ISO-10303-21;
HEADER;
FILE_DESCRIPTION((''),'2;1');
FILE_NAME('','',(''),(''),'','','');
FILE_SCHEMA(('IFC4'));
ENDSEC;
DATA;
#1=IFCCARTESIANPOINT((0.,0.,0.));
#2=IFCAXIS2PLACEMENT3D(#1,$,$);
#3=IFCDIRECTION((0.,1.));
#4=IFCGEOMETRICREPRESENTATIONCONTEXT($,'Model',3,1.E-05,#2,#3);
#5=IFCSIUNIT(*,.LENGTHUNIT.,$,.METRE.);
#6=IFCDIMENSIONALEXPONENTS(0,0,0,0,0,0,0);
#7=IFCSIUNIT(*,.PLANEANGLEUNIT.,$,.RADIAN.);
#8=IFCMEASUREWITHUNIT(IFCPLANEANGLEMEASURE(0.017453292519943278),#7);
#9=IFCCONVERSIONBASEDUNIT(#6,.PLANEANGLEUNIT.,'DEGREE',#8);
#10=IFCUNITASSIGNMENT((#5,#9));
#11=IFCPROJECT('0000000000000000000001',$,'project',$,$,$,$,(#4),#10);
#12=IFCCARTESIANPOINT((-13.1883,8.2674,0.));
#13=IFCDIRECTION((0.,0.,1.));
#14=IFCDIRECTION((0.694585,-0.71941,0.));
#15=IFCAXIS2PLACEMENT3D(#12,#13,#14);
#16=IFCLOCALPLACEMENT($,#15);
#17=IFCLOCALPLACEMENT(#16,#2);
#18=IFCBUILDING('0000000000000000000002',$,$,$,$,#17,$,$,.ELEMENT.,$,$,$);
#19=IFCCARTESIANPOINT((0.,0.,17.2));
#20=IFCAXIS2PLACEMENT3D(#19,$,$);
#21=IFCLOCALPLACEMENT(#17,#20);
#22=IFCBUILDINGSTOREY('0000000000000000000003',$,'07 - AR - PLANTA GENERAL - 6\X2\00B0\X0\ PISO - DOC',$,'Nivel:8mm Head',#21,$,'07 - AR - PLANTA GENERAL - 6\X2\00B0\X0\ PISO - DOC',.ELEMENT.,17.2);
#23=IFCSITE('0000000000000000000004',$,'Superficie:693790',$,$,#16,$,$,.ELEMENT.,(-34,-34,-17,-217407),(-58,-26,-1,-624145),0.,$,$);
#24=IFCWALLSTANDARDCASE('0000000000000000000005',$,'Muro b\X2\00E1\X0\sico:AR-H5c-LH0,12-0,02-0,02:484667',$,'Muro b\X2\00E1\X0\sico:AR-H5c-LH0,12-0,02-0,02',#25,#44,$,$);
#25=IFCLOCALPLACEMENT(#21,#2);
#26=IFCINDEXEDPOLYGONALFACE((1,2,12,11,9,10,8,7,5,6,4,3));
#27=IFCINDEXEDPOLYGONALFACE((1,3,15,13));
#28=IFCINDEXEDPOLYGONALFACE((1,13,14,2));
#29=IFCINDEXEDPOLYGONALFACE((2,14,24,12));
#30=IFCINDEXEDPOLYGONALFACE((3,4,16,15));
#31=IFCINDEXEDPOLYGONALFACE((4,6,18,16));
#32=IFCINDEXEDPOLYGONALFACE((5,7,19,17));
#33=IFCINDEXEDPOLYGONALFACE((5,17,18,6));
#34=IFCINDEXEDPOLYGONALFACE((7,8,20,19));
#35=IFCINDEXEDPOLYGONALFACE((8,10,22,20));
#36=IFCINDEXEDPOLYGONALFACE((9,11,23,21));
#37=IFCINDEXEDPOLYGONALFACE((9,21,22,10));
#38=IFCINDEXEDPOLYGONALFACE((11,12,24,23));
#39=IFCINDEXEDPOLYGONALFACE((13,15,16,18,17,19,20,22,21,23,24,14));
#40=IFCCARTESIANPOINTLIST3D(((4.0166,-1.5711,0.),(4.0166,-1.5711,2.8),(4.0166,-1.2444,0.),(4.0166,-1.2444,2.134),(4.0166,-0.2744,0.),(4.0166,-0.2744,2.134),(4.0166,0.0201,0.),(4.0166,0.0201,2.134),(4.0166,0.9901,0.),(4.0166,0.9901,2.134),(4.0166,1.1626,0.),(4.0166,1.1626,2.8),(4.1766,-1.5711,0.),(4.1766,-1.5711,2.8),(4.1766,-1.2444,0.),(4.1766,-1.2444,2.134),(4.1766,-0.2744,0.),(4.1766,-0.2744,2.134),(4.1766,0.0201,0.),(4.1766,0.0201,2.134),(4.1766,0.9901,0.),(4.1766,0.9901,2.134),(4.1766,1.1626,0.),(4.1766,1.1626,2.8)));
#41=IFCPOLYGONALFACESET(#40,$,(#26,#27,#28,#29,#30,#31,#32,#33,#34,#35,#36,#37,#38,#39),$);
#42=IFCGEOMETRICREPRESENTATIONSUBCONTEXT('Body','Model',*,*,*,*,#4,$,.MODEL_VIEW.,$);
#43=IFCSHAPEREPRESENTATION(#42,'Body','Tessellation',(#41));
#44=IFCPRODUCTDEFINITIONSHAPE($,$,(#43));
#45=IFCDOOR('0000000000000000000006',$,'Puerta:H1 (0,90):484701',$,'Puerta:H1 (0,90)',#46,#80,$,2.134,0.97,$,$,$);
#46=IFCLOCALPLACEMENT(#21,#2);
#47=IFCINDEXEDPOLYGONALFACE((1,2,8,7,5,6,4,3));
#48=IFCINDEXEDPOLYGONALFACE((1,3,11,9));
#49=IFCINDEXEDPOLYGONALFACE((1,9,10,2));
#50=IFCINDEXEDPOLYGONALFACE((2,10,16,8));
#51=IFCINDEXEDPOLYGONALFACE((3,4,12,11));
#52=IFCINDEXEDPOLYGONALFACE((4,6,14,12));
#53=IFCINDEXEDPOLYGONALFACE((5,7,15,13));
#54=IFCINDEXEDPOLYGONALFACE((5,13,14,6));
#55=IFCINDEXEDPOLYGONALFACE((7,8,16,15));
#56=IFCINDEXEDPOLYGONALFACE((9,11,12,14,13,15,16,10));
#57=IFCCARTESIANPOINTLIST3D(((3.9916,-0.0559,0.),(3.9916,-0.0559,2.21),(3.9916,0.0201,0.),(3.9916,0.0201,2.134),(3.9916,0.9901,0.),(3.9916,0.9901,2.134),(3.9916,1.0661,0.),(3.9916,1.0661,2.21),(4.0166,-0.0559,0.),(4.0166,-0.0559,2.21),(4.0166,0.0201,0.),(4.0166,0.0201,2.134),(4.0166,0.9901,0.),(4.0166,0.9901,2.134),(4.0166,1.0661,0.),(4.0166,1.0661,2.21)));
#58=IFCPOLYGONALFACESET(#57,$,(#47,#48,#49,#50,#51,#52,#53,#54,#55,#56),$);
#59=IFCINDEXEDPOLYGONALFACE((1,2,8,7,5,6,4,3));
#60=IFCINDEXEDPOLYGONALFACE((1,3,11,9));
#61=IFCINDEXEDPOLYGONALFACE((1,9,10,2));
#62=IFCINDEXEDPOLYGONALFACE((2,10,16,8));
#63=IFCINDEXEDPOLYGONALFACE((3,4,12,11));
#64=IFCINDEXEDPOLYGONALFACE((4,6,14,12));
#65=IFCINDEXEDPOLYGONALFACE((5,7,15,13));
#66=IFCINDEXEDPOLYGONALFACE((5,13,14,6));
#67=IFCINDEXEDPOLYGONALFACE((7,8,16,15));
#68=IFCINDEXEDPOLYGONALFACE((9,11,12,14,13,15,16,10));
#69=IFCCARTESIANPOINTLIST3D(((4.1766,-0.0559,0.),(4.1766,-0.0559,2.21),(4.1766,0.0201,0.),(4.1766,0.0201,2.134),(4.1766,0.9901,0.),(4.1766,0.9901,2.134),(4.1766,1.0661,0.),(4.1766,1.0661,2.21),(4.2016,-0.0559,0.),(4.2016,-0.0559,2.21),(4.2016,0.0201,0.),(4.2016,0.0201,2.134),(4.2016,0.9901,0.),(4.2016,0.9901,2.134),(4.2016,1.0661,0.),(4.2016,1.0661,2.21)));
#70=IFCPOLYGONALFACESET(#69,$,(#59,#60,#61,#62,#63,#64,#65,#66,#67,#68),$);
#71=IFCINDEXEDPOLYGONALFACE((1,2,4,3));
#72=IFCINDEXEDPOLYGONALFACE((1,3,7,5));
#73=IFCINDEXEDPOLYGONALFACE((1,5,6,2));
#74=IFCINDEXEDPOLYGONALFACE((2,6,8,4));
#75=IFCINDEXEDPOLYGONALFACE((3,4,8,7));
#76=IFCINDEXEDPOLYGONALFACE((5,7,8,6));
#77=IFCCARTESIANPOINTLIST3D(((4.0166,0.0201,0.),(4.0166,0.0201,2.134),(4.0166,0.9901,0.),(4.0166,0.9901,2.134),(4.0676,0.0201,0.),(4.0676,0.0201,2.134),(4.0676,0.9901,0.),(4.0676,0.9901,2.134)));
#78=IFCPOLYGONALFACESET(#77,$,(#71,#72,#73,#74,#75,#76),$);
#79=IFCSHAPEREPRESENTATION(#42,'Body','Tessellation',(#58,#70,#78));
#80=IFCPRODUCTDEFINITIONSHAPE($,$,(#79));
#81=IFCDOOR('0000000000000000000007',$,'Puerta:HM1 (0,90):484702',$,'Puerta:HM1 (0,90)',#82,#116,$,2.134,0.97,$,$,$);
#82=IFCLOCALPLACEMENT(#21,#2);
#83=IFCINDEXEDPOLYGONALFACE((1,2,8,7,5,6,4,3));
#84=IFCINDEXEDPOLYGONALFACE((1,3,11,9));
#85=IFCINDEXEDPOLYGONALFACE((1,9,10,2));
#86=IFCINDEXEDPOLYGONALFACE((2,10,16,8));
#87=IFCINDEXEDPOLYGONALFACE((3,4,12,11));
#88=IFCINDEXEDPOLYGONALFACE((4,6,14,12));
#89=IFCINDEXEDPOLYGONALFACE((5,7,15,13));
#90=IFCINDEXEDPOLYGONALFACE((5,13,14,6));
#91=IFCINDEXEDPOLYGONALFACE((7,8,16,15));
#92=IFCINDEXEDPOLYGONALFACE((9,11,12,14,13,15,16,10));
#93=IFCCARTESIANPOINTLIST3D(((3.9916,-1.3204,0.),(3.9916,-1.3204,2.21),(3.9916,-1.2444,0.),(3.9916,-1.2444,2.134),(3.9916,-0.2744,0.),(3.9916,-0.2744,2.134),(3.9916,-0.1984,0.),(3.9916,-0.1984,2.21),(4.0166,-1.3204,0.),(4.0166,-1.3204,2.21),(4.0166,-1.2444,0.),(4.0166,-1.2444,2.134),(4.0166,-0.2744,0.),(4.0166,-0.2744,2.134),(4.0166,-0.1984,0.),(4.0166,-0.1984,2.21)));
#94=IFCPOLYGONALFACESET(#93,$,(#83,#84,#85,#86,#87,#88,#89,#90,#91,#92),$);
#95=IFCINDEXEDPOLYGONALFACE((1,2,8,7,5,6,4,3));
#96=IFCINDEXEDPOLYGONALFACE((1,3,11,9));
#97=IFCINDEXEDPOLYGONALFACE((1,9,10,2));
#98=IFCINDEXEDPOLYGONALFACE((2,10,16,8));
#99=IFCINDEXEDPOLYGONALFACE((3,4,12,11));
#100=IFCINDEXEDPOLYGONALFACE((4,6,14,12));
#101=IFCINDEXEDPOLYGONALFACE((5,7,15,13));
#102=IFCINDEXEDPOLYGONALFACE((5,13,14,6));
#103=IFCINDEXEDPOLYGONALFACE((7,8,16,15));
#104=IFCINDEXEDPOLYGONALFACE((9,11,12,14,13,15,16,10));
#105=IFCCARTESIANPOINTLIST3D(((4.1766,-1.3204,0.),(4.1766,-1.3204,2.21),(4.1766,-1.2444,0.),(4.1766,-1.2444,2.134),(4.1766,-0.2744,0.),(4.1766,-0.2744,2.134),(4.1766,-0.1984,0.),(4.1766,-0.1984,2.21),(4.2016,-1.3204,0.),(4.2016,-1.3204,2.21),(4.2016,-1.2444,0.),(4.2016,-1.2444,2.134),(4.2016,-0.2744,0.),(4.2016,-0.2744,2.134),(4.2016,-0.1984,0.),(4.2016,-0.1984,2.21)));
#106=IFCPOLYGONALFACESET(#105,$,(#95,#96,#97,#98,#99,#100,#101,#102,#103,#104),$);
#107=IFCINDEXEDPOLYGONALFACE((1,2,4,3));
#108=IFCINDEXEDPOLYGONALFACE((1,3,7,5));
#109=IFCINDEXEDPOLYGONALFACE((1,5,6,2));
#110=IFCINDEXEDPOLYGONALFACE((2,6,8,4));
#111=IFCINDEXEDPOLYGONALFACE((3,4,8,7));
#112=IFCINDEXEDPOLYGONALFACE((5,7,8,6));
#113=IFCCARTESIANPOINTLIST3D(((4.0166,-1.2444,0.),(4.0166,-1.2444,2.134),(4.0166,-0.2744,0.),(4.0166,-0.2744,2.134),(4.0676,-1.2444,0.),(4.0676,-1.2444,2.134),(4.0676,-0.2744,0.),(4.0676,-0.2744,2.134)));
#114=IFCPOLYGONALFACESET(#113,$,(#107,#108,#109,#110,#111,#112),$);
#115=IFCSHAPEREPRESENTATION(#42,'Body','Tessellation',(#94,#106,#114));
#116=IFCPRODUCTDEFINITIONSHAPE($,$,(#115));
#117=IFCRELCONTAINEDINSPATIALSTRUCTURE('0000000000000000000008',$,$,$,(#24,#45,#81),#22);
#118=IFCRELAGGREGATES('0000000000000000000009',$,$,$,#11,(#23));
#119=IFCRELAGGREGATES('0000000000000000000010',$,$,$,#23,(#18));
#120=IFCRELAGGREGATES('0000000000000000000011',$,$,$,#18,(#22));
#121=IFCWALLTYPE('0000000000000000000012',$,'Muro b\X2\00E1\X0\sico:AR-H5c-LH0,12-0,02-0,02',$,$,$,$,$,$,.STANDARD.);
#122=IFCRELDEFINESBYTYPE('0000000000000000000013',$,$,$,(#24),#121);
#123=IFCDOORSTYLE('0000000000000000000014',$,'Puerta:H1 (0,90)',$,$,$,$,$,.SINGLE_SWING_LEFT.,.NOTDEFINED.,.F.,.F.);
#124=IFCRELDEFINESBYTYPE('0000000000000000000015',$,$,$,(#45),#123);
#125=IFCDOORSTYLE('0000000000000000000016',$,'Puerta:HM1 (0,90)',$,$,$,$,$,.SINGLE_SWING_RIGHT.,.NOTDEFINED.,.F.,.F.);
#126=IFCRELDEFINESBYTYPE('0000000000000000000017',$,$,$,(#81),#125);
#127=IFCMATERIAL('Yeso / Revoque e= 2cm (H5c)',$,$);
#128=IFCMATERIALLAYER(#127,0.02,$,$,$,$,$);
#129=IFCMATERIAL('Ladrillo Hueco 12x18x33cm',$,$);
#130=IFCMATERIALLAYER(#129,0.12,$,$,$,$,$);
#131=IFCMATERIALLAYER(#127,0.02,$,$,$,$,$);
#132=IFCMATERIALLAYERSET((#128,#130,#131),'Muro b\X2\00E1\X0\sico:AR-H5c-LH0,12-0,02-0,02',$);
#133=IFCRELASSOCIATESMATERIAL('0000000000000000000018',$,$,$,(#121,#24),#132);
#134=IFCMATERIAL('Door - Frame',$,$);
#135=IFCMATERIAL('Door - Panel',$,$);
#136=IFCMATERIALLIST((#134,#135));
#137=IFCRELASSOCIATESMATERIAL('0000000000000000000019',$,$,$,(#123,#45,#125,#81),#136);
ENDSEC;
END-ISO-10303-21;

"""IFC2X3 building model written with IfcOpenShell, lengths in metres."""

from ifc_helpers import new_model, entity, si_unit, converted_unit, direction, frame, frame_2d, origin, place, context, subcontext, project, spatial, polyline, rectangle, outline, extrude, source, transform, mapped, material, material_list, layer, layer_set, layer_usage, type_object, type_shapes, element, fill, save


model = new_model("IFC2X3")

# Units and contexts
model_context = context("Model", 3, precision=1e-05, world=origin(), true_north=direction((0.0, 1.0)))
body_context = subcontext(model_context, "Body", "Model", "MODEL_VIEW")
ifc_project = project(units=[si_unit("LENGTHUNIT", "METRE"), converted_unit("PLANEANGLEUNIT", "DEGREE", entity("IfcPlaneAngleMeasure", 0.017453292519943278), si_unit("PLANEANGLEUNIT", "RADIAN"), dimensions=[0, 0, 0, 0, 0, 0, 0])], contexts=[model_context])

# Site, building, storey
site_placement = place(None, frame((-13.1883, 8.2674, 0.0), z_axis=(0.0, 0.0, 1.0), x_axis=(0.694585, -0.71941, 0.0)))
site = spatial("IfcSite", under=ifc_project, at=site_placement, Name="Superficie:693790", CompositionType="ELEMENT", RefLatitude=(-34, -34, -17, -217407), RefLongitude=(-58, -26, -1, -624145), RefElevation=0.0)
building_placement = place(site_placement, origin())
building = spatial("IfcBuilding", under=site, at=building_placement, CompositionType="ELEMENT")
storey_placement = place(building_placement, frame((0.0, 0.0, 17.2)))
storey = spatial("IfcBuildingStorey", under=building, at=storey_placement, Name="07 - AR - PLANTA GENERAL - 6° PISO - DOC", ObjectType="Nivel:8mm Head", LongName="07 - AR - PLANTA GENERAL - 6° PISO - DOC", CompositionType="ELEMENT", Elevation=17.2)

# Shared definitions
ifc_material_1 = material(Name="Door - Frame")
ifc_material_2 = material(Name="Door - Panel")
ifc_material_list = material_list([ifc_material_1, ifc_material_2])

# Wall, openings, doors
ifc_material_3 = material(Name="Yeso / Revoque e= 2cm (H5c)")
ifc_layer_1 = layer(ifc_material_3, 0.02)
ifc_material_4 = material(Name="Ladrillo Hueco 12x18x33cm")
ifc_layer_2 = layer(ifc_material_4, 0.12)
ifc_layer_3 = layer(ifc_material_3, 0.02)
ifc_layer_set_1 = layer_set([ifc_layer_1, ifc_layer_2, ifc_layer_3], Name="Muro básico:AR-H5c-LH0,12-0,02-0,02")
ifc_layer_usage_1 = layer_usage(ifc_layer_set_1, "AXIS2", "POSITIVE", -0.08)
wall_type_1 = type_object("IfcWallType", Name="Muro básico:AR-H5c-LH0,12-0,02-0,02", PredefinedType="STANDARD", material=ifc_layer_set_1)
wall_1_placement = place(storey_placement, frame((4.0966, -1.5711, 0.0), z_axis=(0.0, 0.0, 1.0), x_axis=(0.0, 1.0, 0.0)))
wall_1 = element("IfcWallStandardCase", 1, at=wall_1_placement, inside=storey, type_object=wall_type_1, material=ifc_layer_usage_1, Name="Muro básico:AR-H5c-LH0,12-0,02-0,02:484667", ObjectType="Muro básico:AR-H5c-LH0,12-0,02-0,02", context=body_context, shape_type="SweptSolid", body=[
    extrude(rectangle(XDim=2.7337, YDim=0.16, at=frame_2d((1.3668, 0.0), x_axis=(-1.0, 0.0))), origin(), (0.0, 0.0, 1.0), 2.8),
])
opening_1_placement = place(wall_1_placement, frame((1.5912, -0.08, 0.0)))
opening_1 = element("IfcOpeningElement", 2, at=opening_1_placement, cuts=wall_1, ObjectType="Opening", context=body_context, shape_type="SweptSolid", body=[
    extrude(rectangle(XDim=0.97, YDim=2.134, at=frame_2d((1.067, 0.485), x_axis=(0.0, -1.0))), frame((0.0, 0.0, 0.0), z_axis=(0.0, 1.0, 0.0), x_axis=(0.0, 0.0, 1.0)), (0.0, 0.0, 1.0), 0.16),
])
opening_2_placement = place(wall_1_placement, frame((0.3266, -0.08, 0.0)))
opening_2 = element("IfcOpeningElement", 3, at=opening_2_placement, cuts=wall_1, ObjectType="Opening", context=body_context, shape_type="SweptSolid", body=[
    extrude(rectangle(XDim=0.97, YDim=2.134, at=frame_2d((1.067, 0.485), x_axis=(0.0, 1.0))), frame((0.0, 0.0, 0.0), z_axis=(0.0, 1.0, 0.0), x_axis=(0.0, 0.0, 1.0)), (0.0, 0.0, 1.0), 0.16),
])
door_style_1 = type_object("IfcDoorStyle", Name="Puerta:H1 (0,90)", ConstructionType="NOTDEFINED", OperationType="SINGLE_SWING_LEFT", ParameterTakesPrecedence=False, Sizeable=False, material=ifc_material_list)
shared_shape_1 = source(origin(), body_context, "Body", "SweptSolid", [
    extrude(outline(polyline([(-0.561, -1.124), (0.561, -1.124), (0.561, 1.086), (0.485, 1.086), (0.485, -1.048), (-0.485, -1.048), (-0.485, 1.086), (-0.561, 1.086), (-0.561, -1.124)])), frame((0.485, 0.185, 1.086), z_axis=(0.0, -1.0, 0.0), x_axis=(-1.0, 0.0, 0.0)), (0.0, 0.0, 1.0), 0.025),
    extrude(outline(polyline([(-1.124, -0.561), (1.086, -0.561), (1.086, -0.485), (-1.048, -0.485), (-1.048, 0.485), (1.086, 0.485), (1.086, 0.561), (-1.124, 0.561), (-1.124, -0.561)])), frame((0.485, 0.0, 1.086), z_axis=(0.0, -1.0, 0.0), x_axis=(0.0, 0.0, -1.0)), (0.0, 0.0, 1.0), 0.025),
    extrude(rectangle(XDim=0.97, YDim=0.051, at=frame_2d((0.0, 0.0), x_axis=(1.0, 0.0))), frame((0.485, 0.1345, 0.0)), (0.0, 0.0, 1.0), 2.134),
])
type_shapes(door_style_1, [shared_shape_1])
door_1_placement = place(opening_1_placement, origin())
door_1 = element("IfcDoor", 4, at=door_1_placement, inside=storey, type_object=door_style_1, material=ifc_material_list, Name="Puerta:H1 (0,90):484701", ObjectType="Puerta:H1 (0,90)", OverallHeight=2.134, OverallWidth=0.97, context=body_context, shape_type="MappedRepresentation", body=[
    mapped(shared_shape_1, transform((0.0, 0.0, 0.0), scale=1.0)),
])
fill(opening_1, door_1)
door_style_2 = type_object("IfcDoorStyle", Name="Puerta:HM1 (0,90)", ConstructionType="NOTDEFINED", OperationType="SINGLE_SWING_RIGHT", ParameterTakesPrecedence=False, Sizeable=False, material=ifc_material_list)
shared_shape_2 = source(origin(), body_context, "Body", "SweptSolid", [
    extrude(outline(polyline([(-0.561, -1.124), (0.561, -1.124), (0.561, 1.086), (0.485, 1.086), (0.485, -1.048), (-0.485, -1.048), (-0.485, 1.086), (-0.561, 1.086), (-0.561, -1.124)])), frame((0.485, 0.16, 1.086), z_axis=(0.0, 1.0, 0.0), x_axis=(1.0, 0.0, 0.0)), (0.0, 0.0, 1.0), 0.025),
    extrude(outline(polyline([(-1.124, -0.561), (1.086, -0.561), (1.086, -0.485), (-1.048, -0.485), (-1.048, 0.485), (1.086, 0.485), (1.086, 0.561), (-1.124, 0.561), (-1.124, -0.561)])), frame((0.485, -0.025, 1.086), z_axis=(0.0, 1.0, 0.0), x_axis=(0.0, 0.0, -1.0)), (0.0, 0.0, 1.0), 0.025),
    extrude(rectangle(XDim=0.051, YDim=0.97, at=frame_2d((0.0, 0.0), x_axis=(1.0, 0.0))), frame((0.485, 0.1345, 0.0), z_axis=(0.0, 0.0, 1.0), x_axis=(0.0, 1.0, 0.0)), (0.0, 0.0, 1.0), 2.134),
])
type_shapes(door_style_2, [shared_shape_2])
door_2_placement = place(opening_2_placement, origin())
door_2 = element("IfcDoor", 5, at=door_2_placement, inside=storey, type_object=door_style_2, material=ifc_material_list, Name="Puerta:HM1 (0,90):484702", ObjectType="Puerta:HM1 (0,90)", OverallHeight=2.134, OverallWidth=0.97, context=body_context, shape_type="MappedRepresentation", body=[
    mapped(shared_shape_2, transform((0.0, 0.0, 0.0), scale=1.0)),
])
fill(opening_2, door_2)

save(model, "model.ifc")
